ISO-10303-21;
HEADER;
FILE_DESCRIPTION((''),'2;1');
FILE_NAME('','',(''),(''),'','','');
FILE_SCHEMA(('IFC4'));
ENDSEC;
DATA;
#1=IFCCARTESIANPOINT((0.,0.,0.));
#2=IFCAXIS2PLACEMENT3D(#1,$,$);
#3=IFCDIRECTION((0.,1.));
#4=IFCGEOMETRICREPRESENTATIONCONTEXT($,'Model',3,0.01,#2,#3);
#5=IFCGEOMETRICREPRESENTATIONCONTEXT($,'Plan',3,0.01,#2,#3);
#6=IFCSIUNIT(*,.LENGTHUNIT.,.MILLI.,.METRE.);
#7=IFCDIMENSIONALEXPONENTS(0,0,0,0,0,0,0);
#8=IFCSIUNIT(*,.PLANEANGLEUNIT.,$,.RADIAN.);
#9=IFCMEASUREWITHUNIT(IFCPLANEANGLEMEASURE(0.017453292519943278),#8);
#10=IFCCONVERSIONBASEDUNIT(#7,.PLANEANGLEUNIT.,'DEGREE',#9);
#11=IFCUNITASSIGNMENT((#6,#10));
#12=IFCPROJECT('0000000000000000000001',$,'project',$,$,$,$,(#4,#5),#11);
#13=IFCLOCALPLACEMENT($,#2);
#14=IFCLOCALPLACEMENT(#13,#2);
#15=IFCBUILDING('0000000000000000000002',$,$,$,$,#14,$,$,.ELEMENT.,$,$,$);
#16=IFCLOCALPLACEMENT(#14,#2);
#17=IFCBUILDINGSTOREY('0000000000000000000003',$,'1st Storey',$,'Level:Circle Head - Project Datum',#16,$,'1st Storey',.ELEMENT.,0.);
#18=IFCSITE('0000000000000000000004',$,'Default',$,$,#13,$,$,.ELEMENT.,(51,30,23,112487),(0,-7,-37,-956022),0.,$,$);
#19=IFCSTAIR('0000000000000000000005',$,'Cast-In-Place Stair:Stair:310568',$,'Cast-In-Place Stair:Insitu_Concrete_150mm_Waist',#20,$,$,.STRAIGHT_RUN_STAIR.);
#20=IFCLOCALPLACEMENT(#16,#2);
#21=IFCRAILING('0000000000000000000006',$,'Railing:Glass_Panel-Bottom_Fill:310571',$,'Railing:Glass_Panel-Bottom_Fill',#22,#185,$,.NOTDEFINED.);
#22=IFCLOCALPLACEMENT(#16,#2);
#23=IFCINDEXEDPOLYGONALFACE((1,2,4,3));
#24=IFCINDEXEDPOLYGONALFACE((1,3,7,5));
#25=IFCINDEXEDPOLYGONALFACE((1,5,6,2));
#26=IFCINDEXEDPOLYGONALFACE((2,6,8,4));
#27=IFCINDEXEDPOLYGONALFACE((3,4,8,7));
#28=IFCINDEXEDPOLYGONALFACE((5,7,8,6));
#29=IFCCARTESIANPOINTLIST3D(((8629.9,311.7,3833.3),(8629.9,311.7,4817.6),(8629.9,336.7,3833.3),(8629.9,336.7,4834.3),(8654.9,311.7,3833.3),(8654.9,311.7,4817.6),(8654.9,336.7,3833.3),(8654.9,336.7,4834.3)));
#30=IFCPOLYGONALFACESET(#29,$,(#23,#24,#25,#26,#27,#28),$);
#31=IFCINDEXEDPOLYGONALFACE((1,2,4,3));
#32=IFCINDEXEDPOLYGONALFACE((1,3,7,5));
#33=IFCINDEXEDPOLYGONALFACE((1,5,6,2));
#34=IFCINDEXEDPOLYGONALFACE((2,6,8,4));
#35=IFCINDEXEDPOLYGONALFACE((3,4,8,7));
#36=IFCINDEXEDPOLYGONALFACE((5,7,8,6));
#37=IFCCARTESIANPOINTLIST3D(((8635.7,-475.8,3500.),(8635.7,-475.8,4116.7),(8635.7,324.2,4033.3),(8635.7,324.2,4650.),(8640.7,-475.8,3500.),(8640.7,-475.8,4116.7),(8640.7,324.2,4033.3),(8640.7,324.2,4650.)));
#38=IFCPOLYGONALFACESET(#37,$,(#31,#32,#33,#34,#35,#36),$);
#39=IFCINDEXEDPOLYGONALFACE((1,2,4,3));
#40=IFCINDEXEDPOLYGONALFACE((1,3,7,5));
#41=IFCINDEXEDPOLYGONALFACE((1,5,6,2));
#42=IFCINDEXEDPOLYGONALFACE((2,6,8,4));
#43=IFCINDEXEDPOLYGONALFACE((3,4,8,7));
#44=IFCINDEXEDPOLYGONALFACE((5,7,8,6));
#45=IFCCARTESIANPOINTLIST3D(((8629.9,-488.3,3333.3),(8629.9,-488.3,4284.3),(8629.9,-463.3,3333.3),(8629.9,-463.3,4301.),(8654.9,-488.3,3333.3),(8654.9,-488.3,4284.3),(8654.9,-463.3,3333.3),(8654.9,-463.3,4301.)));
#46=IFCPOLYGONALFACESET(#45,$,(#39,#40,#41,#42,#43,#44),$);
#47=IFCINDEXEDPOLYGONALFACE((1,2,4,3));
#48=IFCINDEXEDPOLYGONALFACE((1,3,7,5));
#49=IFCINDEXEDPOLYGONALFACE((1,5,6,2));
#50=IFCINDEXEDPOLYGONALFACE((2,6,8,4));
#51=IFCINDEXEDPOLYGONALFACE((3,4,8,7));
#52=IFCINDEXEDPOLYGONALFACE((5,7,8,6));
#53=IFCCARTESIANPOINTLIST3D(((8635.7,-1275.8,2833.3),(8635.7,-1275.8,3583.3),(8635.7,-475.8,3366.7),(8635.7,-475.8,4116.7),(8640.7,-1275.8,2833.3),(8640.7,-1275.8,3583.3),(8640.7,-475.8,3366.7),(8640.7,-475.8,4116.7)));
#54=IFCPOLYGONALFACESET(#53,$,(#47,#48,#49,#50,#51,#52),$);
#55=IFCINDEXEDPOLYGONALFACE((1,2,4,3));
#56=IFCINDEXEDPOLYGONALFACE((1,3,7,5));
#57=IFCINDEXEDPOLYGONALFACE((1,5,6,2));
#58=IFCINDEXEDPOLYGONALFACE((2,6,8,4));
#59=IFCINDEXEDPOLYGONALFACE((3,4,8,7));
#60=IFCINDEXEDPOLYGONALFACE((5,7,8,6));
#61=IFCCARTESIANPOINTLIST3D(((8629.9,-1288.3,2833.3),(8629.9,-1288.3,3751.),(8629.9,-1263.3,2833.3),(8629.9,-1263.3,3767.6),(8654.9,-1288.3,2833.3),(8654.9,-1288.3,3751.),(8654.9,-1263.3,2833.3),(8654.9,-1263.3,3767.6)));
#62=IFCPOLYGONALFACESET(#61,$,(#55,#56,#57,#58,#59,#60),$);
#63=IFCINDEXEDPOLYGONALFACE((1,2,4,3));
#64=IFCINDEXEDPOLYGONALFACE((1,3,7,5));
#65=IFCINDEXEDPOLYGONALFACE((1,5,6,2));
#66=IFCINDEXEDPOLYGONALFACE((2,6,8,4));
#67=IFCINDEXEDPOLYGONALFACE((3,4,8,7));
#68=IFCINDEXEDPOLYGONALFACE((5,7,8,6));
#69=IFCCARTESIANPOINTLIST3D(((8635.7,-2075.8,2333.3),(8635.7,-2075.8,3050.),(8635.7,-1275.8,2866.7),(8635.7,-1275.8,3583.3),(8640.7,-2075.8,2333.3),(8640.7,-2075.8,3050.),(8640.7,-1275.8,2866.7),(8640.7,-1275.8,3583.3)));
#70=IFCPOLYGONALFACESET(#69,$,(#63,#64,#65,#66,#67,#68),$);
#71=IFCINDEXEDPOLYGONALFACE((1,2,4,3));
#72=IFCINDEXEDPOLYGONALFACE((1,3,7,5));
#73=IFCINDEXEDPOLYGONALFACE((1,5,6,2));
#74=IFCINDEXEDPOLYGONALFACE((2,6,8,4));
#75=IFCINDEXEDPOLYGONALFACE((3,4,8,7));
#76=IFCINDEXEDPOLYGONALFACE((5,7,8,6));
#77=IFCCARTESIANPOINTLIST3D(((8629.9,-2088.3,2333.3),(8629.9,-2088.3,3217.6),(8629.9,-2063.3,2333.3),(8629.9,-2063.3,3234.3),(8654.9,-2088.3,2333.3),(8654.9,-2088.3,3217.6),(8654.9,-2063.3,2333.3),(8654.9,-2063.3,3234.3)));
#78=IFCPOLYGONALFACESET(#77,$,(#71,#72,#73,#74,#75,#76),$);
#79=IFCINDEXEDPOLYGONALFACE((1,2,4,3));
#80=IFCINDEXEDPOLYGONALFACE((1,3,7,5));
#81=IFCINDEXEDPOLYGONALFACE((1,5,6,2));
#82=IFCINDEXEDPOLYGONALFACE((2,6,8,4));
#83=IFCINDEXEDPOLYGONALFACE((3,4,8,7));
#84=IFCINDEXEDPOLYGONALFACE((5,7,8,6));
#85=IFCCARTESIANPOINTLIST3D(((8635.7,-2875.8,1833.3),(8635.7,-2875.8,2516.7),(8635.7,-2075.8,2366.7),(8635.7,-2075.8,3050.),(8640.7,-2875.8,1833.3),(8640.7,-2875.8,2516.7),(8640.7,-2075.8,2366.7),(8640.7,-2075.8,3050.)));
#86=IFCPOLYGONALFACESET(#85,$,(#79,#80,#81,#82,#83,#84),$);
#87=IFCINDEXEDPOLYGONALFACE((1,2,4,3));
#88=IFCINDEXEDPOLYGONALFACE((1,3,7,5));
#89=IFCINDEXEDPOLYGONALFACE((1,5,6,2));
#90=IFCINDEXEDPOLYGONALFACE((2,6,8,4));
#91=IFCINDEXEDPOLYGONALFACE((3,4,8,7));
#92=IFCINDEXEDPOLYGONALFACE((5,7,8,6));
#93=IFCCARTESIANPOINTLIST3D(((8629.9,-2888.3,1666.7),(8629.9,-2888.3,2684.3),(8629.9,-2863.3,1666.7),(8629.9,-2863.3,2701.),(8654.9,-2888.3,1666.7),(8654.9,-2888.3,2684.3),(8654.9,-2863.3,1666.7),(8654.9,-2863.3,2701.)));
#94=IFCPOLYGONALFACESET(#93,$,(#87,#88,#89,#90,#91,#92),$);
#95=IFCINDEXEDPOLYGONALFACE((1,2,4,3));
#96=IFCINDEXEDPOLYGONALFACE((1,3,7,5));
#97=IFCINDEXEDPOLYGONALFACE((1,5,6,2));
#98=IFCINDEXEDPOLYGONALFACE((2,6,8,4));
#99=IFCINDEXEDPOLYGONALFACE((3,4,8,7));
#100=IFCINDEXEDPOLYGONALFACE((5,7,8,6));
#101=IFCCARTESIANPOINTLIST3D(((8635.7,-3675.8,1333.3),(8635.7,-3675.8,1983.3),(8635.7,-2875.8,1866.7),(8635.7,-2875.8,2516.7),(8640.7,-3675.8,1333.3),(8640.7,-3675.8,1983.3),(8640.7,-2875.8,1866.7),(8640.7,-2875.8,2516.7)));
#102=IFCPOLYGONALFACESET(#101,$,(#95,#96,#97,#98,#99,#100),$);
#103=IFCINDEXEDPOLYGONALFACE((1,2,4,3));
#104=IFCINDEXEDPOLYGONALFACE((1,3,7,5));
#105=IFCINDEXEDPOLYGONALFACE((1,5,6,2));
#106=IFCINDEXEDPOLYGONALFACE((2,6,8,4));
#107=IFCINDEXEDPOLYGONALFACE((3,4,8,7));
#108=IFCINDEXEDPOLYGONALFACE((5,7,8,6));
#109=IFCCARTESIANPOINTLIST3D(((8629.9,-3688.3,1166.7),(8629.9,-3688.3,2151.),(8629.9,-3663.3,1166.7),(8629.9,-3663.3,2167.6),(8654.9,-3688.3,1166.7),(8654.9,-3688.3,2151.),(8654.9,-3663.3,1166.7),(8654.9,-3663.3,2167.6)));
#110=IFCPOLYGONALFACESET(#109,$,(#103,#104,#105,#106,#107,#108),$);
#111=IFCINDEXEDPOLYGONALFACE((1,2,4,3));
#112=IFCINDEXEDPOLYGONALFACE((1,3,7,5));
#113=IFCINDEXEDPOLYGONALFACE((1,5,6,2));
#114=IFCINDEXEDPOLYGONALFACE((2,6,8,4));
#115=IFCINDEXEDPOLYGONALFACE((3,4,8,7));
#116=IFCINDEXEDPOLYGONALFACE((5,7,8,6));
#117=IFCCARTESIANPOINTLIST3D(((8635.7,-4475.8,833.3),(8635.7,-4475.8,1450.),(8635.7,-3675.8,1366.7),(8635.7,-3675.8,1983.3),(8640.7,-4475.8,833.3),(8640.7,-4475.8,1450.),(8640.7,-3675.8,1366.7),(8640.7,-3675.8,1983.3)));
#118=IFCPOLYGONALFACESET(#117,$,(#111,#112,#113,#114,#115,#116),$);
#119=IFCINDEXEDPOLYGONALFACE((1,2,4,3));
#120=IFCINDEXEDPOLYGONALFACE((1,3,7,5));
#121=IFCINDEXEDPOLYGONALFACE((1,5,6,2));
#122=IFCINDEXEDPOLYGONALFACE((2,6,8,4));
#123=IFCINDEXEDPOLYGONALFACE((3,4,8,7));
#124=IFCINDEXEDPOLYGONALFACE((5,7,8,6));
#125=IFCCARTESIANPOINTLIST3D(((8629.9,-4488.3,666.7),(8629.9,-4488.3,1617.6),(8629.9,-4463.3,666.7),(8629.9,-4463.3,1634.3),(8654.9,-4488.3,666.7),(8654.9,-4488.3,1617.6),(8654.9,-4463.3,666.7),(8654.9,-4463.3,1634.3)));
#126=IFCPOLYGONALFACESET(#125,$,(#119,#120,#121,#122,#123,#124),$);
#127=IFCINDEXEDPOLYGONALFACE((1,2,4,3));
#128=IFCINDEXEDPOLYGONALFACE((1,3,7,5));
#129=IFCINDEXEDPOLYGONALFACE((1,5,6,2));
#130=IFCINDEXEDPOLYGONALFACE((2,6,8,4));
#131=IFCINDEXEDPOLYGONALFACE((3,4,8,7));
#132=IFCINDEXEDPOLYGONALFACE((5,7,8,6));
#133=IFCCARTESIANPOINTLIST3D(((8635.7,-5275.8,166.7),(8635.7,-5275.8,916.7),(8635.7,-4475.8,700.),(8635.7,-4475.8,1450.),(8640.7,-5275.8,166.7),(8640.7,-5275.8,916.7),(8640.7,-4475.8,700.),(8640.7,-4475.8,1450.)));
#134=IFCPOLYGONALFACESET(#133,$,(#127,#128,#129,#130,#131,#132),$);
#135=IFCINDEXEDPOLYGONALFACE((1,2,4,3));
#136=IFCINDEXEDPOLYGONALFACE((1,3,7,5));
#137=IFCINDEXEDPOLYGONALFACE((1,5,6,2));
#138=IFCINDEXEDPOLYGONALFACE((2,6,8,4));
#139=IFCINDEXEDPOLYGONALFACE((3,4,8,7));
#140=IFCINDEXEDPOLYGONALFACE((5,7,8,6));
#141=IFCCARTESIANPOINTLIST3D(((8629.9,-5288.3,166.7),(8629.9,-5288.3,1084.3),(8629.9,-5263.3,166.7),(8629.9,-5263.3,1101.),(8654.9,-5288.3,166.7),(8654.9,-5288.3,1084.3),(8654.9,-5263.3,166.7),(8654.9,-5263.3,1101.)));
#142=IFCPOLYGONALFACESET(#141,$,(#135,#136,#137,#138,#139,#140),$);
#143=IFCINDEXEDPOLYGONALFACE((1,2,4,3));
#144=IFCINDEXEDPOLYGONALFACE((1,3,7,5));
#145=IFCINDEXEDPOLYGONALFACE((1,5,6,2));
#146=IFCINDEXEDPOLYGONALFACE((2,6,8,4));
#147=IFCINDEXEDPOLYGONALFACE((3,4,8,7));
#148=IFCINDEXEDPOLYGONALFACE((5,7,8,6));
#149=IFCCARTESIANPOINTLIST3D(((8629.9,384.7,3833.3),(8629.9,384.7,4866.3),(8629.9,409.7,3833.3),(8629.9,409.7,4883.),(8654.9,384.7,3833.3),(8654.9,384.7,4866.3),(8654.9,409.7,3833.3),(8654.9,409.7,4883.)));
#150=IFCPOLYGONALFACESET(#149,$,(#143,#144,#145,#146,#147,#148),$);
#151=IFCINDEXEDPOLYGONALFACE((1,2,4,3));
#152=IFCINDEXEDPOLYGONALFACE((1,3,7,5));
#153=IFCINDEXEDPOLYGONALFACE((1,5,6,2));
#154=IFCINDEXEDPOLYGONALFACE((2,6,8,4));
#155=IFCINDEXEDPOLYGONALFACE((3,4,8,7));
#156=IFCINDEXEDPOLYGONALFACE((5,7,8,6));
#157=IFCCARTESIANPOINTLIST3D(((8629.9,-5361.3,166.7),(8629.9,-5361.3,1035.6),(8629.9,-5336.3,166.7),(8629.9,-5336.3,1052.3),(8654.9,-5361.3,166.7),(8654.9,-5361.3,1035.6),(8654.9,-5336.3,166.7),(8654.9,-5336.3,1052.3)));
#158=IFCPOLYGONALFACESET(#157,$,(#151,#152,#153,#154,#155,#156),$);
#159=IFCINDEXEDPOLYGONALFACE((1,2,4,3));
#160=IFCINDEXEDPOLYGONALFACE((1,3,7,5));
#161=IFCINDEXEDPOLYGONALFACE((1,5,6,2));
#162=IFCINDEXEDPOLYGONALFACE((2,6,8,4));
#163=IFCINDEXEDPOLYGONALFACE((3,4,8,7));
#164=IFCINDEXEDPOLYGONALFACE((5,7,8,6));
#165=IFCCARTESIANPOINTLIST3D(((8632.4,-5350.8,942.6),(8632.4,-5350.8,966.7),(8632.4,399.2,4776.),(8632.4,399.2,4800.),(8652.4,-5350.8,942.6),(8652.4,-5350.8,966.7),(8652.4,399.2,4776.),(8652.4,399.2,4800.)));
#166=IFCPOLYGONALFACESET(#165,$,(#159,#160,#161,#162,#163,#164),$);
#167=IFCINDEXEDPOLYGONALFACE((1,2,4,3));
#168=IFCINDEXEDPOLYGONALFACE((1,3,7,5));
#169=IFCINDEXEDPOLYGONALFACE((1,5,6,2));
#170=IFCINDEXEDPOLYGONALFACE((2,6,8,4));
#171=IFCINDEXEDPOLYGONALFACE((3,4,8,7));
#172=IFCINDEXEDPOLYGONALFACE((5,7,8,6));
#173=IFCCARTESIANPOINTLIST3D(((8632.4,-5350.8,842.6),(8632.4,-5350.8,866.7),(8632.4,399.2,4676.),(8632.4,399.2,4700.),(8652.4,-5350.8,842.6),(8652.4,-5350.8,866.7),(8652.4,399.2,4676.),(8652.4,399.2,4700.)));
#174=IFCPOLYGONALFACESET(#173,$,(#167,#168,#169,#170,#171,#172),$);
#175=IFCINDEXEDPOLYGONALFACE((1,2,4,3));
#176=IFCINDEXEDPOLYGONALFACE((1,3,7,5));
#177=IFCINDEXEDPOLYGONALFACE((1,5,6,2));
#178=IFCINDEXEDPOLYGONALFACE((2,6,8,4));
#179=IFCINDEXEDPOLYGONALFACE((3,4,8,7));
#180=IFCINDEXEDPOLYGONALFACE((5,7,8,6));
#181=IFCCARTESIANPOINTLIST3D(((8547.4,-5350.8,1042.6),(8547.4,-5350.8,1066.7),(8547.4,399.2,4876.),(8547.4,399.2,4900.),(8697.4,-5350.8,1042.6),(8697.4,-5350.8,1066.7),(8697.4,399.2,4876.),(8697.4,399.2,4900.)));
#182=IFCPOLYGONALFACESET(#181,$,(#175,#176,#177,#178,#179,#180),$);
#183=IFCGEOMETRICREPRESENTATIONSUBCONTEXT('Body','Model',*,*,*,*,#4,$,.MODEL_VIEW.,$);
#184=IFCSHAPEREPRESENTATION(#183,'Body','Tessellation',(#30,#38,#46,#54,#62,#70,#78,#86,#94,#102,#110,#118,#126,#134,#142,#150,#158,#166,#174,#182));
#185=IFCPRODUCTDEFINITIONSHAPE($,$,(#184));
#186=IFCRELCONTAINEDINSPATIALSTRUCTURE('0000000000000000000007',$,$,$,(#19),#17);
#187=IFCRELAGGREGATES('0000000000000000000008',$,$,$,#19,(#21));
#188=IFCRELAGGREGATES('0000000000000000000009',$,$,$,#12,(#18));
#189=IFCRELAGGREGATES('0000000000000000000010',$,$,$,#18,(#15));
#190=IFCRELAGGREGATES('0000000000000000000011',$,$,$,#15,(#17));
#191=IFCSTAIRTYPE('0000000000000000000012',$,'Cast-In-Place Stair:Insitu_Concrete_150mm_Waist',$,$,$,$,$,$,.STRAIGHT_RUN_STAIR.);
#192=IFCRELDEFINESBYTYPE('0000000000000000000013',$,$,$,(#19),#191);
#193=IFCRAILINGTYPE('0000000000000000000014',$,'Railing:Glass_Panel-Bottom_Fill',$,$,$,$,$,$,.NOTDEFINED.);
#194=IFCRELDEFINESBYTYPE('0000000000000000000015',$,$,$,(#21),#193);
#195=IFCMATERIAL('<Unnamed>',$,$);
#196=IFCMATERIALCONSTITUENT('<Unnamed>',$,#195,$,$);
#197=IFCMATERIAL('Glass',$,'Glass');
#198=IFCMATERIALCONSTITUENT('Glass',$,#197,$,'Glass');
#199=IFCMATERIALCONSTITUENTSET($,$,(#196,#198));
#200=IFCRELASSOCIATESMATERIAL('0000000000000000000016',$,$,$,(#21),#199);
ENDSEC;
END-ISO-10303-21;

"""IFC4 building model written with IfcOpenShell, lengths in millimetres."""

from ifc_helpers import new_model, entity, si_unit, converted_unit, direction, frame, origin, place, context, subcontext, project, spatial, indexed_curve, outline, extrude, material, constituent, constituent_set, type_object, element, aggregate, save


model = new_model("IFC4")

# Units and contexts
model_context = context("Model", 3, precision=0.01, world=origin(), true_north=direction((0.0, 1.0)))
plan_context = context("Plan", 3, precision=0.01, world=origin(), true_north=direction((0.0, 1.0)))
body_context = subcontext(model_context, "Body", "Model", "MODEL_VIEW")
ifc_project = project(units=[si_unit("LENGTHUNIT", "METRE", prefix="MILLI"), converted_unit("PLANEANGLEUNIT", "DEGREE", entity("IfcPlaneAngleMeasure", 0.017453292519943278), si_unit("PLANEANGLEUNIT", "RADIAN"), dimensions=[0, 0, 0, 0, 0, 0, 0])], contexts=[model_context, plan_context])

# Site, building, storey
site_placement = place(None, origin())
site = spatial("IfcSite", under=ifc_project, at=site_placement, Name="Default", CompositionType="ELEMENT", RefLatitude=(51, 30, 23, 112487), RefLongitude=(0, -7, -37, -956022), RefElevation=0.0)
building_placement = place(site_placement, origin())
building = spatial("IfcBuilding", under=site, at=building_placement, CompositionType="ELEMENT")
storey_placement = place(building_placement, origin())
storey = spatial("IfcBuildingStorey", under=building, at=storey_placement, Name="1st Storey", ObjectType="Level:Circle Head - Project Datum", LongName="1st Storey", CompositionType="ELEMENT", Elevation=0.0)

# Shared definitions
ifc_material_1 = material(Name="<Unnamed>")

# Stair, railing
stair_type_1 = type_object("IfcStairType", Name="Cast-In-Place Stair:Insitu_Concrete_150mm_Waist", PredefinedType="STRAIGHT_RUN_STAIR")
ifc_material_2 = material(Name="Glass", Category="Glass")
railing_type = type_object("IfcRailingType", Name="Railing:Glass_Panel-Bottom_Fill", PredefinedType="NOTDEFINED")
stair_1_placement = place(storey_placement, origin())
stair_1 = element("IfcStair", 1, at=stair_1_placement, inside=storey, type_object=stair_type_1, Name="Cast-In-Place Stair:Stair:310568", ObjectType="Cast-In-Place Stair:Insitu_Concrete_150mm_Waist", PredefinedType="STRAIGHT_RUN_STAIR")
ifc_constituent_1 = constituent(ifc_material_1, Name="<Unnamed>")
ifc_constituent_2 = constituent(ifc_material_2, Name="Glass", Category="Glass")
ifc_constituent_set_1 = constituent_set(constituents=[ifc_constituent_1, ifc_constituent_2])
railing_1_placement = place(stair_1_placement, frame((8547.4, -5361.3, 166.7)))
railing_1 = element("IfcRailing", 2, at=railing_1_placement, type_object=railing_type, material=ifc_constituent_set_1, Name="Railing:Glass_Panel-Bottom_Fill:310571", ObjectType="Railing:Glass_Panel-Bottom_Fill", PredefinedType="NOTDEFINED", context=body_context, shape_type="SweptSolid", body=[
    extrude(outline(indexed_curve([(-488.0, -12.5), (496.3, -12.5), (496.3, 12.5), (-504.6, 12.5), (-488.0, -12.5)], self_intersect=False)), frame((82.5, 5685.5, 4163.0), z_axis=(1.0, 0.0, 0.0), x_axis=(0.0, 0.0, -1.0)), (0.0, 0.0, 1.0), 25.0),
    extrude(outline(indexed_curve([(-41.7, -400.0), (575.0, -400.0), (41.7, 400.0), (-575.0, 400.0), (-41.7, -400.0)], self_intersect=False)), frame((88.3, 5285.5, 3908.3), z_axis=(1.0, 0.0, 0.0), x_axis=(0.0, 0.0, -1.0)), (0.0, 0.0, 1.0), 5.0),
    extrude(outline(indexed_curve([(-471.3, -12.5), (479.6, -12.5), (479.6, 12.5), (-488.0, 12.5), (-471.3, -12.5)], self_intersect=False)), frame((82.5, 4885.5, 3646.3), z_axis=(1.0, 0.0, 0.0), x_axis=(0.0, 0.0, -1.0)), (0.0, 0.0, 1.0), 25.0),
    extrude(outline(indexed_curve([(-108.3, -400.0), (641.7, -400.0), (108.3, 400.0), (-641.7, 400.0), (-108.3, -400.0)], self_intersect=False)), frame((88.3, 4485.5, 3308.3), z_axis=(1.0, 0.0, 0.0), x_axis=(0.0, 0.0, -1.0)), (0.0, 0.0, 1.0), 5.0),
    extrude(outline(indexed_curve([(-454.6, -12.5), (463.0, -12.5), (463.0, 12.5), (-471.3, 12.5), (-454.6, -12.5)], self_intersect=False)), frame((82.5, 4085.5, 3129.6), z_axis=(1.0, 0.0, 0.0), x_axis=(0.0, 0.0, -1.0)), (0.0, 0.0, 1.0), 25.0),
    extrude(outline(indexed_curve([(-91.7, -400.0), (625.0, -400.0), (91.7, 400.0), (-625.0, 400.0), (-91.7, -400.0)], self_intersect=False)), frame((88.3, 3685.5, 2791.7), z_axis=(1.0, 0.0, 0.0), x_axis=(0.0, 0.0, -1.0)), (0.0, 0.0, 1.0), 5.0),
    extrude(outline(indexed_curve([(-438.0, -12.5), (446.3, -12.5), (446.3, 12.5), (-454.6, 12.5), (-438.0, -12.5)], self_intersect=False)), frame((82.5, 3285.5, 2613.0), z_axis=(1.0, 0.0, 0.0), x_axis=(0.0, 0.0, -1.0)), (0.0, 0.0, 1.0), 25.0),
    extrude(outline(indexed_curve([(-75.0, -400.0), (608.3, -400.0), (75.0, 400.0), (-608.3, 400.0), (-75.0, -400.0)], self_intersect=False)), frame((88.3, 2885.5, 2275.0), z_axis=(1.0, 0.0, 0.0), x_axis=(0.0, 0.0, -1.0)), (0.0, 0.0, 1.0), 5.0),
    extrude(outline(indexed_curve([(-504.6, -12.5), (513.0, -12.5), (513.0, 12.5), (-521.3, 12.5), (-504.6, -12.5)], self_intersect=False)), frame((82.5, 2485.5, 2013.0), z_axis=(1.0, 0.0, 0.0), x_axis=(0.0, 0.0, -1.0)), (0.0, 0.0, 1.0), 25.0),
    extrude(outline(indexed_curve([(-58.3, -400.0), (591.7, -400.0), (58.3, 400.0), (-591.7, 400.0), (-58.3, -400.0)], self_intersect=False)), frame((88.3, 2085.5, 1758.3), z_axis=(1.0, 0.0, 0.0), x_axis=(0.0, 0.0, -1.0)), (0.0, 0.0, 1.0), 5.0),
    extrude(outline(indexed_curve([(-488.0, -12.5), (496.3, -12.5), (496.3, 12.5), (-504.6, 12.5), (-488.0, -12.5)], self_intersect=False)), frame((82.5, 1685.5, 1496.3), z_axis=(1.0, 0.0, 0.0), x_axis=(0.0, 0.0, -1.0)), (0.0, 0.0, 1.0), 25.0),
    extrude(outline(indexed_curve([(-41.7, -400.0), (575.0, -400.0), (41.7, 400.0), (-575.0, 400.0), (-41.7, -400.0)], self_intersect=False)), frame((88.3, 1285.5, 1241.7), z_axis=(1.0, 0.0, 0.0), x_axis=(0.0, 0.0, -1.0)), (0.0, 0.0, 1.0), 5.0),
    extrude(outline(indexed_curve([(-471.3, -12.5), (479.6, -12.5), (479.6, 12.5), (-488.0, 12.5), (-471.3, -12.5)], self_intersect=False)), frame((82.5, 885.5, 979.6), z_axis=(1.0, 0.0, 0.0), x_axis=(0.0, 0.0, -1.0)), (0.0, 0.0, 1.0), 25.0),
    extrude(outline(indexed_curve([(-108.3, -400.0), (641.7, -400.0), (108.3, 400.0), (-641.7, 400.0), (-108.3, -400.0)], self_intersect=False)), frame((88.3, 485.5, 641.7), z_axis=(1.0, 0.0, 0.0), x_axis=(0.0, 0.0, -1.0)), (0.0, 0.0, 1.0), 5.0),
    extrude(outline(indexed_curve([(-454.6, -12.5), (463.0, -12.5), (463.0, 12.5), (-471.3, 12.5), (-454.6, -12.5)], self_intersect=False)), frame((82.5, 85.5, 463.0), z_axis=(1.0, 0.0, 0.0), x_axis=(0.0, 0.0, -1.0)), (0.0, 0.0, 1.0), 25.0),
    extrude(outline(indexed_curve([(-512.3, -12.5), (520.6, -12.5), (520.6, 12.5), (-529.0, 12.5), (-512.3, -12.5)], self_intersect=False)), frame((82.5, 5758.5, 4187.3), z_axis=(1.0, 0.0, 0.0), x_axis=(0.0, 0.0, -1.0)), (0.0, 0.0, 1.0), 25.0),
    extrude(outline(indexed_curve([(-430.3, -12.5), (438.6, -12.5), (438.6, 12.5), (-447.0, 12.5), (-430.3, -12.5)], self_intersect=False)), frame((82.5, 12.5, 438.6), z_axis=(1.0, 0.0, 0.0), x_axis=(0.0, 0.0, -1.0)), (0.0, 0.0, 1.0), 25.0),
    extrude(outline(indexed_curve([(-3462.0, -10.0), (3448.7, -10.0), (3462.0, 10.0), (-3448.7, 10.0), (-3462.0, -10.0)], self_intersect=False)), frame((85.0, 2885.5, 2704.6), z_axis=(1.0, 0.0, 0.0), x_axis=(0.0, 0.83205, 0.5547)), (0.0, 0.0, 1.0), 20.0),
    extrude(outline(indexed_curve([(-3462.0, -10.0), (3448.7, -10.0), (3462.0, 10.0), (-3448.7, 10.0), (-3462.0, -10.0)], self_intersect=False)), frame((85.0, 2885.5, 2604.6), z_axis=(1.0, 0.0, 0.0), x_axis=(0.0, 0.83205, 0.5547)), (0.0, 0.0, 1.0), 20.0),
    extrude(outline(indexed_curve([(-3462.0, -10.0), (3448.7, -10.0), (3462.0, 10.0), (-3448.7, 10.0), (-3462.0, -10.0)], self_intersect=False)), frame((0.0, 2885.5, 2804.6), z_axis=(1.0, 0.0, 0.0), x_axis=(0.0, 0.83205, 0.5547)), (0.0, 0.0, 1.0), 150.0),
])
aggregate(stair_1, [railing_1])

save(model, "model.ifc")
